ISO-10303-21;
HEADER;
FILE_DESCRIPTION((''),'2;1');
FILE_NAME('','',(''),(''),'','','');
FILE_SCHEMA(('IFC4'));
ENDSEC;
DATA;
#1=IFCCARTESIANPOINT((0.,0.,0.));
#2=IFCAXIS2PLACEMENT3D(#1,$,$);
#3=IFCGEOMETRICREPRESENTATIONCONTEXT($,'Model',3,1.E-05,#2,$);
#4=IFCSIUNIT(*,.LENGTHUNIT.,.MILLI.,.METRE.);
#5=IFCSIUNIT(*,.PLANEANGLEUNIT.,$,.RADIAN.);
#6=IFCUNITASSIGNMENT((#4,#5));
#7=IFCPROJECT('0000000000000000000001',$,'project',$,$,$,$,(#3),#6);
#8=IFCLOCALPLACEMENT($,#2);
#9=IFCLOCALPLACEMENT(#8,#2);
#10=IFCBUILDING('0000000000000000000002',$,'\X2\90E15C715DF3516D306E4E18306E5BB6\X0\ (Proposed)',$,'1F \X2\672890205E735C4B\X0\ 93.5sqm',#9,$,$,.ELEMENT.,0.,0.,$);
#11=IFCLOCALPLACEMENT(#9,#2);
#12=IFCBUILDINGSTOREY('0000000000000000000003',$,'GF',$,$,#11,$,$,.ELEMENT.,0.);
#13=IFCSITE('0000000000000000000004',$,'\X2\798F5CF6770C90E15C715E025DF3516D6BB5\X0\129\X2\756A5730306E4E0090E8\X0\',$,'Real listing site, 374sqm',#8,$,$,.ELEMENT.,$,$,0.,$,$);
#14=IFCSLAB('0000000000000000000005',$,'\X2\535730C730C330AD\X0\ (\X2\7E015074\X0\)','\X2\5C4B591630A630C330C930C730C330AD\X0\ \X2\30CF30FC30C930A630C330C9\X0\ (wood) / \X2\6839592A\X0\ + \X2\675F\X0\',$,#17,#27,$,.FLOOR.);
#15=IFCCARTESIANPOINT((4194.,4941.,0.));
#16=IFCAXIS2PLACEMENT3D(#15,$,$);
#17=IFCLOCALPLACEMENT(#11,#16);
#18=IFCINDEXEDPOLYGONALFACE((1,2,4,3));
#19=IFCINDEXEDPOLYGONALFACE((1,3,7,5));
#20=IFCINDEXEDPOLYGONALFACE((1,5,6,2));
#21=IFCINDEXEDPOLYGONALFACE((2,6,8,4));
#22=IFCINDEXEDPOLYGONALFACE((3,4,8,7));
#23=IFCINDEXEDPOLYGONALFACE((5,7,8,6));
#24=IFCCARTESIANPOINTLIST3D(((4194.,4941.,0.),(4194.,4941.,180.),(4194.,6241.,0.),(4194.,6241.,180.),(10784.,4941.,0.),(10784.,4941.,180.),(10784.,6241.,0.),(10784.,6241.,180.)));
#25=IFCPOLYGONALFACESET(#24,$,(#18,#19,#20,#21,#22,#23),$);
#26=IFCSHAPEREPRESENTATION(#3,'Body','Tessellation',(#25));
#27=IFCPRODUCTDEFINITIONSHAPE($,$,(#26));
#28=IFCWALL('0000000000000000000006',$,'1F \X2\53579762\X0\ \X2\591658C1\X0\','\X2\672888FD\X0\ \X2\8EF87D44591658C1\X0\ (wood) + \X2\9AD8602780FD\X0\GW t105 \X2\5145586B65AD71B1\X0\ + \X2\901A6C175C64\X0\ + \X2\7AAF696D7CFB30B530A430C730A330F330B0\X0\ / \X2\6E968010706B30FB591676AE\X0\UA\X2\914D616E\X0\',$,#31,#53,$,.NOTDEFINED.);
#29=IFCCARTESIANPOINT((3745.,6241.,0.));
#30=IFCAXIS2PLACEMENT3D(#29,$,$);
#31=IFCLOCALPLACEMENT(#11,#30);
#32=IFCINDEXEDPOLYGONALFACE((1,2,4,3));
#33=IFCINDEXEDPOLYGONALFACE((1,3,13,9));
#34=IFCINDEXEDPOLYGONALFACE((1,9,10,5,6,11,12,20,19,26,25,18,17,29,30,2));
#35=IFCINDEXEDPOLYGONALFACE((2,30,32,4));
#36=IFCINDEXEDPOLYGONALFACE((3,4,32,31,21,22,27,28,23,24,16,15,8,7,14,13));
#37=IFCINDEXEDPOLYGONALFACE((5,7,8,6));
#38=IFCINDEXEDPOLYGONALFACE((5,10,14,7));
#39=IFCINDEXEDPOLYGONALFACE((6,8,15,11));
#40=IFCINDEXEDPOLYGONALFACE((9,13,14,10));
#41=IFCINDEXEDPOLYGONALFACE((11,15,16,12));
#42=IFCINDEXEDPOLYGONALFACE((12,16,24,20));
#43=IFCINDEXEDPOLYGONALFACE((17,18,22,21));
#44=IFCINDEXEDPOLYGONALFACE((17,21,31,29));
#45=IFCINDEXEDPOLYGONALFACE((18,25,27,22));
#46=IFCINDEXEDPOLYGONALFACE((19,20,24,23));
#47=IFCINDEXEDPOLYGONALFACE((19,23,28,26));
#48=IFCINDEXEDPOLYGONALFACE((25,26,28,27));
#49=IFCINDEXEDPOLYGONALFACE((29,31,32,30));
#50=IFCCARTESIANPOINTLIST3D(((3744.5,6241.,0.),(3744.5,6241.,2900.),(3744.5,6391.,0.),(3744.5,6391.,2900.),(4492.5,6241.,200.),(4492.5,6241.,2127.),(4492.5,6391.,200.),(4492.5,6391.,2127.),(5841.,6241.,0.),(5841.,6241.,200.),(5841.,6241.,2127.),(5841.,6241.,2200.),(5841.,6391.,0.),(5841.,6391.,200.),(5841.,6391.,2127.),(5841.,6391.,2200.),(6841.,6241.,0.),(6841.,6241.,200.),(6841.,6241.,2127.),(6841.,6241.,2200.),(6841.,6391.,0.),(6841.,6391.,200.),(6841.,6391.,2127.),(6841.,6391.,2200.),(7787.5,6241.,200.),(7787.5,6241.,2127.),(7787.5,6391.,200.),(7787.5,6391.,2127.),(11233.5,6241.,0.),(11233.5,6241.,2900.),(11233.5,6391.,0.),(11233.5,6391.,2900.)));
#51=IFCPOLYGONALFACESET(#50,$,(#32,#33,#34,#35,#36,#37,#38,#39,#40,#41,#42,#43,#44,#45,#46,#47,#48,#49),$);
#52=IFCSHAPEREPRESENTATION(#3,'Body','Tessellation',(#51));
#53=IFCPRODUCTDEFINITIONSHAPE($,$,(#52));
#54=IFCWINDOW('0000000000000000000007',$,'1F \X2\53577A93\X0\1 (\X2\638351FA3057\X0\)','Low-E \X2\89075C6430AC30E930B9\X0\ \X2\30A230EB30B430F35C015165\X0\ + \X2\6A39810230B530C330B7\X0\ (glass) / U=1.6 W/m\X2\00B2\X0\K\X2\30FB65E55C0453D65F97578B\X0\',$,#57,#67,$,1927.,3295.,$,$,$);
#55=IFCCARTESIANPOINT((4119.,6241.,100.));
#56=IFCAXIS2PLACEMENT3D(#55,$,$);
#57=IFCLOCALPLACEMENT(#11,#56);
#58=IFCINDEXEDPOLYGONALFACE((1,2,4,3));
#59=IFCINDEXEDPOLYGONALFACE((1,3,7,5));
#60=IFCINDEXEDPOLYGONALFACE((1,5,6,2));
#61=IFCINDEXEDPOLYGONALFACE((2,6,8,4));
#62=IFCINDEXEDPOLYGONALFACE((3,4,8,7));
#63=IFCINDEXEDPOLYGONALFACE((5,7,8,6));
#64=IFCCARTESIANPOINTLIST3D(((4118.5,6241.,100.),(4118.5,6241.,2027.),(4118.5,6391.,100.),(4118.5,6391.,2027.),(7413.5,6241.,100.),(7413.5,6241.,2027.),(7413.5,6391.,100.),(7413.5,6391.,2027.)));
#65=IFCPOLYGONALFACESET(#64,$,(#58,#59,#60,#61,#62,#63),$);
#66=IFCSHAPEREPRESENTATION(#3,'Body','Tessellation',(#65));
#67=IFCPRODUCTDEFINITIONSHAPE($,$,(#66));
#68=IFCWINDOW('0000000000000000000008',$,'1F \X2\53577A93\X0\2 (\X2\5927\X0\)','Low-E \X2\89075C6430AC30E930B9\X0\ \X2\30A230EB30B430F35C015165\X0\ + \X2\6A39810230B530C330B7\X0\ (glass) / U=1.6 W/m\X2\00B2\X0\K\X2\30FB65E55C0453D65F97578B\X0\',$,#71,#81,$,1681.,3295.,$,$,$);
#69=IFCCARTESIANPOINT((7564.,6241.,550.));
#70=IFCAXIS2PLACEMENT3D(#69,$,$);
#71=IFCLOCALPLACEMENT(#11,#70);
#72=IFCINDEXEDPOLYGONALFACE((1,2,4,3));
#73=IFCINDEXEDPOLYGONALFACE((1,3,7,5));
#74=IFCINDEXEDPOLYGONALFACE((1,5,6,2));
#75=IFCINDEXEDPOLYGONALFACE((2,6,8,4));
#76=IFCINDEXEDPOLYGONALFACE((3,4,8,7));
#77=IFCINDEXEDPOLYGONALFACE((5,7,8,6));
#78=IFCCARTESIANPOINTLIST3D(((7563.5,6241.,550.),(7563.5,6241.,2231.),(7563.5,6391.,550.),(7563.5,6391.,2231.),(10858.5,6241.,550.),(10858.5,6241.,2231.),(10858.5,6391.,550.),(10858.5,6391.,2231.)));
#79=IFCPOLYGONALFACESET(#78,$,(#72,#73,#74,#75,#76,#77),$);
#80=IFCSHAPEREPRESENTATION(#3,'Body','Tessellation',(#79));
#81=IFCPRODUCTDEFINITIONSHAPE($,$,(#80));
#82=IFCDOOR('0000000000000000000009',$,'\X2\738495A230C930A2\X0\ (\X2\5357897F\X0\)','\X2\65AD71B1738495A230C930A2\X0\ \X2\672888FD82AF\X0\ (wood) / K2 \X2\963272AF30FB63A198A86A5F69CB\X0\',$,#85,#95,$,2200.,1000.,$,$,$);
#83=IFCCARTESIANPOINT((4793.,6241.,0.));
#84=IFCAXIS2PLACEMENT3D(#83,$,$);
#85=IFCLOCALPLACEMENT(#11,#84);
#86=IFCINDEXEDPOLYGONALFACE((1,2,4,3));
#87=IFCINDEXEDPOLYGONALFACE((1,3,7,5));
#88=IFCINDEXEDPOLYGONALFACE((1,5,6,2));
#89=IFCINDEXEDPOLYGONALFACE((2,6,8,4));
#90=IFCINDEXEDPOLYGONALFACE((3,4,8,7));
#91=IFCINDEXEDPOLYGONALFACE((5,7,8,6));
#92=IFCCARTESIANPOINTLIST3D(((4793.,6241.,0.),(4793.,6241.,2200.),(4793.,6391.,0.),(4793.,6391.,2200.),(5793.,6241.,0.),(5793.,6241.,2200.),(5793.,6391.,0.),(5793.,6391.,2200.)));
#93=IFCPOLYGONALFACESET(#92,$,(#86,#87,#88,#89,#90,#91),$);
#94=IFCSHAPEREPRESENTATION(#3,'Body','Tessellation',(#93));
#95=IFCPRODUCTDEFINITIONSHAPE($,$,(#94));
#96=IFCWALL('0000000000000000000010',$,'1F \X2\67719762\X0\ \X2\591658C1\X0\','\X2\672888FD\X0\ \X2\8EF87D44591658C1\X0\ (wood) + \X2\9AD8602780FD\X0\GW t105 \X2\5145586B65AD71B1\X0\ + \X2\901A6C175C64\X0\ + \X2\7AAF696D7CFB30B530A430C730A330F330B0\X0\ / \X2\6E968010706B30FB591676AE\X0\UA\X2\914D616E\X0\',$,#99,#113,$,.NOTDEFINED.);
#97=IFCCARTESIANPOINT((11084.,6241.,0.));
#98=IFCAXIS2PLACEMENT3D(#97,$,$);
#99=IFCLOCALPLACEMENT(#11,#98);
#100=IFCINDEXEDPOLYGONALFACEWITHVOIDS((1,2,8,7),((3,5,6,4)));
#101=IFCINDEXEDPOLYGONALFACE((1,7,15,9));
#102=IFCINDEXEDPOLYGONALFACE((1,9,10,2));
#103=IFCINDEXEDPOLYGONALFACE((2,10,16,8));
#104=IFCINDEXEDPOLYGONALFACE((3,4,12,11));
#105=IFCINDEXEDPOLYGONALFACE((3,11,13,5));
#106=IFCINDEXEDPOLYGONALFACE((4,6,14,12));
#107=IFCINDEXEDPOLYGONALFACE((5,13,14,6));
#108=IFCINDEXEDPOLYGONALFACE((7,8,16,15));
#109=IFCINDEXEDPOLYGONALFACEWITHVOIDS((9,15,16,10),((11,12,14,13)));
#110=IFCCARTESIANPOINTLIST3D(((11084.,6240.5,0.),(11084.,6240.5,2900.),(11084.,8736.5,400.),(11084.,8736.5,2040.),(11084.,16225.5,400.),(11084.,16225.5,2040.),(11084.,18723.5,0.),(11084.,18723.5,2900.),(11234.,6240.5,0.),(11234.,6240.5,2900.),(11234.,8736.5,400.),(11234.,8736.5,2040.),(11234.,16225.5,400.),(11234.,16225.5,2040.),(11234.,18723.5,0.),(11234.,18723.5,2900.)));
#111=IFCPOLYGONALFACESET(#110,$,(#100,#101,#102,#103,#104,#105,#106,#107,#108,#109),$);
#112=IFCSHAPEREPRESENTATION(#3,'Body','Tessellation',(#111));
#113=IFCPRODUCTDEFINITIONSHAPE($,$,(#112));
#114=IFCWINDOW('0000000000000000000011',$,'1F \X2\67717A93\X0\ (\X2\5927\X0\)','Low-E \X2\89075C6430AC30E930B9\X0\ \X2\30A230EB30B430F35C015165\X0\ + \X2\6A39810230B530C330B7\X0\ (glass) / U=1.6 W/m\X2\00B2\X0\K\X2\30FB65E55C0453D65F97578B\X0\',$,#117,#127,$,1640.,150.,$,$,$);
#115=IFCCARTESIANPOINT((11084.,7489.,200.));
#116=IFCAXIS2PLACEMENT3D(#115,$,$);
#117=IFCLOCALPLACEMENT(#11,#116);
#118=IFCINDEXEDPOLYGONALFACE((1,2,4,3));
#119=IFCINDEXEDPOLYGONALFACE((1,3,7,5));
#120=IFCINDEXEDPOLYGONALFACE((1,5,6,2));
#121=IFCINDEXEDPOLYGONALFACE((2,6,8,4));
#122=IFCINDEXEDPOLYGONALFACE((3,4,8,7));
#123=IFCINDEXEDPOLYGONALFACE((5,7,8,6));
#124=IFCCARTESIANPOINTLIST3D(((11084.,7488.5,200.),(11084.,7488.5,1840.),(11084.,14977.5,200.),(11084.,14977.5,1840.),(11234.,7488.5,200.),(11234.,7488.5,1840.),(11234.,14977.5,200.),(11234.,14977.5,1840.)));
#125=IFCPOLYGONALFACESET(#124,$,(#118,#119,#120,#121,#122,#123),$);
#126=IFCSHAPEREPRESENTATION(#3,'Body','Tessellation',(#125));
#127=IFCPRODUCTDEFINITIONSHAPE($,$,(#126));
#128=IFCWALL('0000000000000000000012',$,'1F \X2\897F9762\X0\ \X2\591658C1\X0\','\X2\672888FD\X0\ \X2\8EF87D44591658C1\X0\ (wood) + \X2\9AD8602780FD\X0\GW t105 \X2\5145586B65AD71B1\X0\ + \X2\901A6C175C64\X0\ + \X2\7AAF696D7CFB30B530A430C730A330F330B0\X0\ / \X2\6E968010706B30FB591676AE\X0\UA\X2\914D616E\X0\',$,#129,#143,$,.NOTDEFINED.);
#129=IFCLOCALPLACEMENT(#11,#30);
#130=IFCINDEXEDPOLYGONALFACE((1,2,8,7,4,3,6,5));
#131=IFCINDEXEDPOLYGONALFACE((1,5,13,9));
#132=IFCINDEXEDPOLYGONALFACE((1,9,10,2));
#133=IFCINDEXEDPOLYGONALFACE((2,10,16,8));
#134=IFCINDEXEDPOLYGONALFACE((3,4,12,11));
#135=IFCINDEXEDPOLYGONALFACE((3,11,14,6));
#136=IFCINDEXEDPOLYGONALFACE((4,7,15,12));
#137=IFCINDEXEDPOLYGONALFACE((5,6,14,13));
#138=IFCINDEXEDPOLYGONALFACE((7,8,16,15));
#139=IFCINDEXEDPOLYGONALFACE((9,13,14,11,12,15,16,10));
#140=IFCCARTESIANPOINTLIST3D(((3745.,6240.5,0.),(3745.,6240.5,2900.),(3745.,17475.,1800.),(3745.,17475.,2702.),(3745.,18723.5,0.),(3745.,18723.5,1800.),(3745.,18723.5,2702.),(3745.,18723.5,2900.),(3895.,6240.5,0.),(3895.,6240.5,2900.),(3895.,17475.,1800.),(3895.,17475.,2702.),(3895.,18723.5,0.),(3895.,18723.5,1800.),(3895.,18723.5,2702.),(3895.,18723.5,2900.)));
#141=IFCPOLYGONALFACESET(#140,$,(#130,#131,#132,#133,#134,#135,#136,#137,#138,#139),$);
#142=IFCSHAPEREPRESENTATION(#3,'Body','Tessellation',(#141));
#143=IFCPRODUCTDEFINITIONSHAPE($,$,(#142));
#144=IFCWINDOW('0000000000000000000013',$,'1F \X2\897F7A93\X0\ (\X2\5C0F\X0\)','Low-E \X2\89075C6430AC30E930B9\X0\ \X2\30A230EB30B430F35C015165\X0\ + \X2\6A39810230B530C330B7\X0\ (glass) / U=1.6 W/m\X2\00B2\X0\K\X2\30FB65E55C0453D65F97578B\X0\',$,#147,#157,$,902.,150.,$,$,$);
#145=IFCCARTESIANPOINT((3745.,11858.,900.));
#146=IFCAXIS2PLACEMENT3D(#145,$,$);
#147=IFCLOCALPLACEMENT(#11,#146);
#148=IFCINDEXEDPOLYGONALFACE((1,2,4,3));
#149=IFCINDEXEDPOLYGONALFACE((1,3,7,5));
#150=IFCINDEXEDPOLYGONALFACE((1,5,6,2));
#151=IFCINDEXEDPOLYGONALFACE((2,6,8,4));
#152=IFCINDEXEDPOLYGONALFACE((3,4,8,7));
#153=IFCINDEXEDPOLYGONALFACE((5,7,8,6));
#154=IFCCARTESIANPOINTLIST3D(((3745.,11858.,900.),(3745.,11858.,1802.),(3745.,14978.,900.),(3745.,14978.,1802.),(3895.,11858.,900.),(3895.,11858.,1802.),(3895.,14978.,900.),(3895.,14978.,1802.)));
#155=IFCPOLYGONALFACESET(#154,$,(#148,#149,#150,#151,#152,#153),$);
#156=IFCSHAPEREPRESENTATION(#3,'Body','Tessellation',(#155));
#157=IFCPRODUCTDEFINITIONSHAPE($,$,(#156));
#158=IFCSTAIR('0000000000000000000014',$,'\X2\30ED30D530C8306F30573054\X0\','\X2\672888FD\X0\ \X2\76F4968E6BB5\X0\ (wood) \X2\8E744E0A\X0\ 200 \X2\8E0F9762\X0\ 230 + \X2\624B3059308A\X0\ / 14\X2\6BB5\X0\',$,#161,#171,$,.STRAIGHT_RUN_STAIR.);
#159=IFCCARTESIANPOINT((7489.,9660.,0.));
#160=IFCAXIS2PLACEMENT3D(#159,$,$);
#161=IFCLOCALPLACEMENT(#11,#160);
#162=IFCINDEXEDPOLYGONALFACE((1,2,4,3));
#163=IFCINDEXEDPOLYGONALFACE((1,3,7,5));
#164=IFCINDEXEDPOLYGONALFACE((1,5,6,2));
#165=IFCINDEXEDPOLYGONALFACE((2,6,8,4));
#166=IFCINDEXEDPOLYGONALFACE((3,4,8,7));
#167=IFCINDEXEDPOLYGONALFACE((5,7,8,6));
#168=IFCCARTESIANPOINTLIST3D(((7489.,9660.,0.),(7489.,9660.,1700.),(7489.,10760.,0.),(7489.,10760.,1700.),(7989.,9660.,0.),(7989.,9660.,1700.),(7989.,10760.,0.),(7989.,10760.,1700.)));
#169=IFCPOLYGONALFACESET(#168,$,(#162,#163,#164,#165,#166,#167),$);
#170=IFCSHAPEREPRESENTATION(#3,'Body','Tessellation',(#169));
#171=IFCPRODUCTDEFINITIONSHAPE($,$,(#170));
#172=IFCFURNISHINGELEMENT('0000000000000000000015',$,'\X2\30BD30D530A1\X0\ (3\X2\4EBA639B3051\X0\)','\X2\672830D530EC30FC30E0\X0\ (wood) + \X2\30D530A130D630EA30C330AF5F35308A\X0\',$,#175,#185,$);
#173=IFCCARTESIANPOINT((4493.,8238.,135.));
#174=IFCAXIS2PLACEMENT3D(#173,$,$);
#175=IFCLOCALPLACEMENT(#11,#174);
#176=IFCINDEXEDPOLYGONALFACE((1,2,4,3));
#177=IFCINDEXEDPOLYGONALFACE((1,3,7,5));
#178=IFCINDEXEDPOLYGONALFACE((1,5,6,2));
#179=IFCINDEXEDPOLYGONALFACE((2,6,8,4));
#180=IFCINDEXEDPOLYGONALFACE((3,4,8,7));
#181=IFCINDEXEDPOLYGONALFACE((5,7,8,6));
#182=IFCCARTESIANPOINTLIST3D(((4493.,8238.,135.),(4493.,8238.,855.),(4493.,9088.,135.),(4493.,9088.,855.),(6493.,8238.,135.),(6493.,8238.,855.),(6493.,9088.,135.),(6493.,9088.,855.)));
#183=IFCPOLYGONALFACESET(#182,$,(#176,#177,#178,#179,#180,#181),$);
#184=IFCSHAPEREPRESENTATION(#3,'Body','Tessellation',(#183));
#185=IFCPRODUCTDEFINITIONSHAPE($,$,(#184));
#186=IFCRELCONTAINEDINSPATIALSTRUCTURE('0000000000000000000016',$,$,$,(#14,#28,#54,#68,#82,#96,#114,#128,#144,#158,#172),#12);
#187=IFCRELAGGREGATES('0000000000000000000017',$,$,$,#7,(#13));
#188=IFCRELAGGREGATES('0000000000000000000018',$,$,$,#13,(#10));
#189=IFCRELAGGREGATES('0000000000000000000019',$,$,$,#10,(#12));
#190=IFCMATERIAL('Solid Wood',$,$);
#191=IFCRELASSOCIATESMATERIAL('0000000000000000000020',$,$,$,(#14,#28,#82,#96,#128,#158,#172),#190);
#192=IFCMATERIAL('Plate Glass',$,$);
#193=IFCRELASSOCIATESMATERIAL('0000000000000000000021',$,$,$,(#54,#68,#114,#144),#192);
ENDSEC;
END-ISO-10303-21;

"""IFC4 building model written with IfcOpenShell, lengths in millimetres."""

from ifc_helpers import new_model, si_unit, frame, frame_2d, origin, place, context, project, spatial, rectangle, extrude, material, element, fill, save


model = new_model("IFC4")

# Units and contexts
model_context = context("Model", 3, precision=1e-05, world=origin())
ifc_project = project(units=[si_unit("LENGTHUNIT", "METRE", prefix="MILLI"), si_unit("PLANEANGLEUNIT", "RADIAN")], contexts=[model_context])

# Site, building, storey
site_placement = place(None, origin())
site = spatial("IfcSite", under=ifc_project, at=site_placement, Name="福島県郡山市巳六段129番地の一部", ObjectType="Real listing site, 374sqm", CompositionType="ELEMENT", RefElevation=0.0)
building_placement = place(site_placement, origin())
building = spatial("IfcBuilding", under=site, at=building_placement, Name="郡山巳六の丘の家 (Proposed)", ObjectType="1F 木造平屋 93.5sqm", CompositionType="ELEMENT", ElevationOfRefHeight=0.0, ElevationOfTerrain=0.0)
storey_placement = place(building_placement, origin())
storey = spatial("IfcBuildingStorey", under=building, at=storey_placement, Name="GF", CompositionType="ELEMENT", Elevation=0.0)

# Slab
ifc_material_1 = material(Name="Solid Wood")
slab_1_placement = place(storey_placement, frame((4194.0, 4941.0, 0.0)))
element("IfcSlab", 1, at=slab_1_placement, inside=storey, material=ifc_material_1, Name="南デッキ (縁側)", Description="屋外ウッドデッキ ハードウッド (wood) / 根太 + 束", PredefinedType="FLOOR", context=model_context, shape_type="SweptSolid", body=[
    extrude(rectangle(XDim=6590.0, YDim=1300.0, at=frame_2d((3295.0, 650.0))), frame((4194.0, 4941.0, 0.0)), (0.0, 0.0, 1.0), 180.0),
])

# Wall, openings, windows, door
wall_1_placement = place(storey_placement, frame((3745.0, 6241.0, 0.0)))
wall_1 = element("IfcWall", 2, at=wall_1_placement, inside=storey, material=ifc_material_1, Name="1F 南面 外壁", Description="木製 軸組外壁 (wood) + 高性能GW t105 充填断熱 + 通気層 + 窯業系サイディング / 準耐火・外皮UA配慮", PredefinedType="NOTDEFINED", context=model_context, shape_type="SweptSolid", body=[
    extrude(rectangle(XDim=7489.0, YDim=150.0, at=frame_2d((3744.0, 75.0))), frame((3745.0, 6241.0, 0.0)), (0.0, 0.0, 1.0), 2900.0),
])
opening_1_placement = place(storey_placement, frame((4119.0, 6241.0, 100.0)))
opening_1 = element("IfcOpeningElement", 3, at=opening_1_placement, cuts=wall_1, PredefinedType="NOTDEFINED", context=model_context, shape_type="SweptSolid", body=[
    extrude(rectangle(XDim=3295.0, YDim=150.0, at=frame_2d((1647.0, 75.0))), frame((4119.0, 6241.0, 100.0)), (0.0, 0.0, 1.0), 1927.0),
])
opening_2_placement = place(storey_placement, frame((7564.0, 6241.0, 550.0)))
opening_2 = element("IfcOpeningElement", 4, at=opening_2_placement, cuts=wall_1, PredefinedType="NOTDEFINED", context=model_context, shape_type="SweptSolid", body=[
    extrude(rectangle(XDim=3295.0, YDim=150.0, at=frame_2d((1647.0, 75.0))), frame((7564.0, 6241.0, 550.0)), (0.0, 0.0, 1.0), 1681.0),
])
opening_3_placement = place(storey_placement, frame((4793.0, 6241.0, 0.0)))
opening_3 = element("IfcOpeningElement", 5, at=opening_3_placement, cuts=wall_1, PredefinedType="NOTDEFINED", context=model_context, shape_type="SweptSolid", body=[
    extrude(rectangle(XDim=1000.0, YDim=150.0, at=frame_2d((500.0, 75.0))), frame((4793.0, 6241.0, 0.0)), (0.0, 0.0, 1.0), 2200.0),
])
ifc_material_2 = material(Name="Plate Glass")
window_1_placement = place(storey_placement, frame((4119.0, 6241.0, 100.0)))
window_1 = element("IfcWindow", 6, at=window_1_placement, inside=storey, material=ifc_material_2, Name="1F 南窓1 (掃出し)", Description="Low-E 複層ガラス アルゴン封入 + 樹脂サッシ (glass) / U=1.6 W/m²K・日射取得型", OverallHeight=1927.0, OverallWidth=3295.0, context=model_context, shape_type="SweptSolid", body=[
    extrude(rectangle(XDim=3295.0, YDim=150.0, at=frame_2d((1647.0, 75.0))), frame((4119.0, 6241.0, 100.0)), (0.0, 0.0, 1.0), 1927.0),
])
fill(opening_1, window_1)
window_2_placement = place(storey_placement, frame((7564.0, 6241.0, 550.0)))
window_2 = element("IfcWindow", 7, at=window_2_placement, inside=storey, material=ifc_material_2, Name="1F 南窓2 (大)", Description="Low-E 複層ガラス アルゴン封入 + 樹脂サッシ (glass) / U=1.6 W/m²K・日射取得型", OverallHeight=1681.0, OverallWidth=3295.0, context=model_context, shape_type="SweptSolid", body=[
    extrude(rectangle(XDim=3295.0, YDim=150.0, at=frame_2d((1647.0, 75.0))), frame((7564.0, 6241.0, 550.0)), (0.0, 0.0, 1.0), 1681.0),
])
fill(opening_2, window_2)
door_placement = place(storey_placement, frame((4793.0, 6241.0, 0.0)))
door = element("IfcDoor", 8, at=door_placement, inside=storey, material=ifc_material_1, Name="玄関ドア (南西)", Description="断熱玄関ドア 木製芯 (wood) / K2 防犯・採風機構", OverallHeight=2200.0, OverallWidth=1000.0, context=model_context, shape_type="SweptSolid", body=[
    extrude(rectangle(XDim=1000.0, YDim=150.0, at=frame_2d((500.0, 75.0))), frame((4793.0, 6241.0, 0.0)), (0.0, 0.0, 1.0), 2200.0),
])
fill(opening_3, door)

# Walls, openings, windows
wall_2_placement = place(storey_placement, frame((11084.0, 6241.0, 0.0)))
wall_2 = element("IfcWall", 9, at=wall_2_placement, inside=storey, material=ifc_material_1, Name="1F 東面 外壁", Description="木製 軸組外壁 (wood) + 高性能GW t105 充填断熱 + 通気層 + 窯業系サイディング / 準耐火・外皮UA配慮", PredefinedType="NOTDEFINED", context=model_context, shape_type="SweptSolid", body=[
    extrude(rectangle(XDim=150.0, YDim=12483.0, at=frame_2d((75.0, 6241.0))), frame((11084.0, 6241.0, 0.0)), (0.0, 0.0, 1.0), 2900.0),
])
opening_4_placement = place(storey_placement, frame((11084.0, 7489.0, 200.0)))
opening_4 = element("IfcOpeningElement", 10, at=opening_4_placement, cuts=wall_2, PredefinedType="NOTDEFINED", context=model_context, shape_type="SweptSolid", body=[
    extrude(rectangle(XDim=150.0, YDim=7489.0, at=frame_2d((75.0, 3744.0))), frame((11084.0, 7489.0, 200.0)), (0.0, 0.0, 1.0), 1640.0),
])
window_3_placement = place(storey_placement, frame((11084.0, 7489.0, 200.0)))
window_3 = element("IfcWindow", 11, at=window_3_placement, inside=storey, material=ifc_material_2, Name="1F 東窓 (大)", Description="Low-E 複層ガラス アルゴン封入 + 樹脂サッシ (glass) / U=1.6 W/m²K・日射取得型", OverallHeight=1640.0, OverallWidth=150.0, context=model_context, shape_type="SweptSolid", body=[
    extrude(rectangle(XDim=150.0, YDim=7489.0, at=frame_2d((75.0, 3744.0))), frame((11084.0, 7489.0, 200.0)), (0.0, 0.0, 1.0), 1640.0),
])
fill(opening_4, window_3)
wall_3_placement = place(storey_placement, frame((3745.0, 6241.0, 0.0)))
wall_3 = element("IfcWall", 12, at=wall_3_placement, inside=storey, material=ifc_material_1, Name="1F 西面 外壁", Description="木製 軸組外壁 (wood) + 高性能GW t105 充填断熱 + 通気層 + 窯業系サイディング / 準耐火・外皮UA配慮", PredefinedType="NOTDEFINED", context=model_context, shape_type="SweptSolid", body=[
    extrude(rectangle(XDim=150.0, YDim=12483.0, at=frame_2d((75.0, 6241.0))), frame((3745.0, 6241.0, 0.0)), (0.0, 0.0, 1.0), 2900.0),
])
opening_5_placement = place(storey_placement, frame((3745.0, 11858.0, 900.0)))
opening_5 = element("IfcOpeningElement", 13, at=opening_5_placement, cuts=wall_3, PredefinedType="NOTDEFINED", context=model_context, shape_type="SweptSolid", body=[
    extrude(rectangle(XDim=150.0, YDim=3120.0, at=frame_2d((75.0, 1560.0))), frame((3745.0, 11858.0, 900.0)), (0.0, 0.0, 1.0), 902.0),
])
window_4_placement = place(storey_placement, frame((3745.0, 11858.0, 900.0)))
window_4 = element("IfcWindow", 14, at=window_4_placement, inside=storey, material=ifc_material_2, Name="1F 西窓 (小)", Description="Low-E 複層ガラス アルゴン封入 + 樹脂サッシ (glass) / U=1.6 W/m²K・日射取得型", OverallHeight=902.0, OverallWidth=150.0, context=model_context, shape_type="SweptSolid", body=[
    extrude(rectangle(XDim=150.0, YDim=3120.0, at=frame_2d((75.0, 1560.0))), frame((3745.0, 11858.0, 900.0)), (0.0, 0.0, 1.0), 902.0),
])
fill(opening_5, window_4)

# Stair
stair_placement = place(storey_placement, frame((7489.0, 9660.0, 0.0)))
element("IfcStair", 15, at=stair_placement, inside=storey, material=ifc_material_1, Name="ロフトはしご", Description="木製 直階段 (wood) 蹴上 200 踏面 230 + 手すり / 14段", PredefinedType="STRAIGHT_RUN_STAIR", context=model_context, shape_type="SweptSolid", body=[
    extrude(rectangle(XDim=500.0, YDim=1100.0, at=frame_2d((250.0, 550.0))), frame((7489.0, 9660.0, 0.0)), (0.0, 0.0, 1.0), 1700.0),
])

# Furnishing element
furnishing_1_placement = place(storey_placement, frame((4493.0, 8238.0, 135.0)))
element("IfcFurnishingElement", 16, at=furnishing_1_placement, inside=storey, material=ifc_material_1, Name="ソファ (3人掛け)", Description="木フレーム (wood) + ファブリック張り", context=model_context, shape_type="SweptSolid", body=[
    extrude(rectangle(XDim=2000.0, YDim=850.0, at=frame_2d((1000.0, 425.0))), frame((4493.0, 8238.0, 135.0)), (0.0, 0.0, 1.0), 720.0),
])

save(model, "model.ifc")
